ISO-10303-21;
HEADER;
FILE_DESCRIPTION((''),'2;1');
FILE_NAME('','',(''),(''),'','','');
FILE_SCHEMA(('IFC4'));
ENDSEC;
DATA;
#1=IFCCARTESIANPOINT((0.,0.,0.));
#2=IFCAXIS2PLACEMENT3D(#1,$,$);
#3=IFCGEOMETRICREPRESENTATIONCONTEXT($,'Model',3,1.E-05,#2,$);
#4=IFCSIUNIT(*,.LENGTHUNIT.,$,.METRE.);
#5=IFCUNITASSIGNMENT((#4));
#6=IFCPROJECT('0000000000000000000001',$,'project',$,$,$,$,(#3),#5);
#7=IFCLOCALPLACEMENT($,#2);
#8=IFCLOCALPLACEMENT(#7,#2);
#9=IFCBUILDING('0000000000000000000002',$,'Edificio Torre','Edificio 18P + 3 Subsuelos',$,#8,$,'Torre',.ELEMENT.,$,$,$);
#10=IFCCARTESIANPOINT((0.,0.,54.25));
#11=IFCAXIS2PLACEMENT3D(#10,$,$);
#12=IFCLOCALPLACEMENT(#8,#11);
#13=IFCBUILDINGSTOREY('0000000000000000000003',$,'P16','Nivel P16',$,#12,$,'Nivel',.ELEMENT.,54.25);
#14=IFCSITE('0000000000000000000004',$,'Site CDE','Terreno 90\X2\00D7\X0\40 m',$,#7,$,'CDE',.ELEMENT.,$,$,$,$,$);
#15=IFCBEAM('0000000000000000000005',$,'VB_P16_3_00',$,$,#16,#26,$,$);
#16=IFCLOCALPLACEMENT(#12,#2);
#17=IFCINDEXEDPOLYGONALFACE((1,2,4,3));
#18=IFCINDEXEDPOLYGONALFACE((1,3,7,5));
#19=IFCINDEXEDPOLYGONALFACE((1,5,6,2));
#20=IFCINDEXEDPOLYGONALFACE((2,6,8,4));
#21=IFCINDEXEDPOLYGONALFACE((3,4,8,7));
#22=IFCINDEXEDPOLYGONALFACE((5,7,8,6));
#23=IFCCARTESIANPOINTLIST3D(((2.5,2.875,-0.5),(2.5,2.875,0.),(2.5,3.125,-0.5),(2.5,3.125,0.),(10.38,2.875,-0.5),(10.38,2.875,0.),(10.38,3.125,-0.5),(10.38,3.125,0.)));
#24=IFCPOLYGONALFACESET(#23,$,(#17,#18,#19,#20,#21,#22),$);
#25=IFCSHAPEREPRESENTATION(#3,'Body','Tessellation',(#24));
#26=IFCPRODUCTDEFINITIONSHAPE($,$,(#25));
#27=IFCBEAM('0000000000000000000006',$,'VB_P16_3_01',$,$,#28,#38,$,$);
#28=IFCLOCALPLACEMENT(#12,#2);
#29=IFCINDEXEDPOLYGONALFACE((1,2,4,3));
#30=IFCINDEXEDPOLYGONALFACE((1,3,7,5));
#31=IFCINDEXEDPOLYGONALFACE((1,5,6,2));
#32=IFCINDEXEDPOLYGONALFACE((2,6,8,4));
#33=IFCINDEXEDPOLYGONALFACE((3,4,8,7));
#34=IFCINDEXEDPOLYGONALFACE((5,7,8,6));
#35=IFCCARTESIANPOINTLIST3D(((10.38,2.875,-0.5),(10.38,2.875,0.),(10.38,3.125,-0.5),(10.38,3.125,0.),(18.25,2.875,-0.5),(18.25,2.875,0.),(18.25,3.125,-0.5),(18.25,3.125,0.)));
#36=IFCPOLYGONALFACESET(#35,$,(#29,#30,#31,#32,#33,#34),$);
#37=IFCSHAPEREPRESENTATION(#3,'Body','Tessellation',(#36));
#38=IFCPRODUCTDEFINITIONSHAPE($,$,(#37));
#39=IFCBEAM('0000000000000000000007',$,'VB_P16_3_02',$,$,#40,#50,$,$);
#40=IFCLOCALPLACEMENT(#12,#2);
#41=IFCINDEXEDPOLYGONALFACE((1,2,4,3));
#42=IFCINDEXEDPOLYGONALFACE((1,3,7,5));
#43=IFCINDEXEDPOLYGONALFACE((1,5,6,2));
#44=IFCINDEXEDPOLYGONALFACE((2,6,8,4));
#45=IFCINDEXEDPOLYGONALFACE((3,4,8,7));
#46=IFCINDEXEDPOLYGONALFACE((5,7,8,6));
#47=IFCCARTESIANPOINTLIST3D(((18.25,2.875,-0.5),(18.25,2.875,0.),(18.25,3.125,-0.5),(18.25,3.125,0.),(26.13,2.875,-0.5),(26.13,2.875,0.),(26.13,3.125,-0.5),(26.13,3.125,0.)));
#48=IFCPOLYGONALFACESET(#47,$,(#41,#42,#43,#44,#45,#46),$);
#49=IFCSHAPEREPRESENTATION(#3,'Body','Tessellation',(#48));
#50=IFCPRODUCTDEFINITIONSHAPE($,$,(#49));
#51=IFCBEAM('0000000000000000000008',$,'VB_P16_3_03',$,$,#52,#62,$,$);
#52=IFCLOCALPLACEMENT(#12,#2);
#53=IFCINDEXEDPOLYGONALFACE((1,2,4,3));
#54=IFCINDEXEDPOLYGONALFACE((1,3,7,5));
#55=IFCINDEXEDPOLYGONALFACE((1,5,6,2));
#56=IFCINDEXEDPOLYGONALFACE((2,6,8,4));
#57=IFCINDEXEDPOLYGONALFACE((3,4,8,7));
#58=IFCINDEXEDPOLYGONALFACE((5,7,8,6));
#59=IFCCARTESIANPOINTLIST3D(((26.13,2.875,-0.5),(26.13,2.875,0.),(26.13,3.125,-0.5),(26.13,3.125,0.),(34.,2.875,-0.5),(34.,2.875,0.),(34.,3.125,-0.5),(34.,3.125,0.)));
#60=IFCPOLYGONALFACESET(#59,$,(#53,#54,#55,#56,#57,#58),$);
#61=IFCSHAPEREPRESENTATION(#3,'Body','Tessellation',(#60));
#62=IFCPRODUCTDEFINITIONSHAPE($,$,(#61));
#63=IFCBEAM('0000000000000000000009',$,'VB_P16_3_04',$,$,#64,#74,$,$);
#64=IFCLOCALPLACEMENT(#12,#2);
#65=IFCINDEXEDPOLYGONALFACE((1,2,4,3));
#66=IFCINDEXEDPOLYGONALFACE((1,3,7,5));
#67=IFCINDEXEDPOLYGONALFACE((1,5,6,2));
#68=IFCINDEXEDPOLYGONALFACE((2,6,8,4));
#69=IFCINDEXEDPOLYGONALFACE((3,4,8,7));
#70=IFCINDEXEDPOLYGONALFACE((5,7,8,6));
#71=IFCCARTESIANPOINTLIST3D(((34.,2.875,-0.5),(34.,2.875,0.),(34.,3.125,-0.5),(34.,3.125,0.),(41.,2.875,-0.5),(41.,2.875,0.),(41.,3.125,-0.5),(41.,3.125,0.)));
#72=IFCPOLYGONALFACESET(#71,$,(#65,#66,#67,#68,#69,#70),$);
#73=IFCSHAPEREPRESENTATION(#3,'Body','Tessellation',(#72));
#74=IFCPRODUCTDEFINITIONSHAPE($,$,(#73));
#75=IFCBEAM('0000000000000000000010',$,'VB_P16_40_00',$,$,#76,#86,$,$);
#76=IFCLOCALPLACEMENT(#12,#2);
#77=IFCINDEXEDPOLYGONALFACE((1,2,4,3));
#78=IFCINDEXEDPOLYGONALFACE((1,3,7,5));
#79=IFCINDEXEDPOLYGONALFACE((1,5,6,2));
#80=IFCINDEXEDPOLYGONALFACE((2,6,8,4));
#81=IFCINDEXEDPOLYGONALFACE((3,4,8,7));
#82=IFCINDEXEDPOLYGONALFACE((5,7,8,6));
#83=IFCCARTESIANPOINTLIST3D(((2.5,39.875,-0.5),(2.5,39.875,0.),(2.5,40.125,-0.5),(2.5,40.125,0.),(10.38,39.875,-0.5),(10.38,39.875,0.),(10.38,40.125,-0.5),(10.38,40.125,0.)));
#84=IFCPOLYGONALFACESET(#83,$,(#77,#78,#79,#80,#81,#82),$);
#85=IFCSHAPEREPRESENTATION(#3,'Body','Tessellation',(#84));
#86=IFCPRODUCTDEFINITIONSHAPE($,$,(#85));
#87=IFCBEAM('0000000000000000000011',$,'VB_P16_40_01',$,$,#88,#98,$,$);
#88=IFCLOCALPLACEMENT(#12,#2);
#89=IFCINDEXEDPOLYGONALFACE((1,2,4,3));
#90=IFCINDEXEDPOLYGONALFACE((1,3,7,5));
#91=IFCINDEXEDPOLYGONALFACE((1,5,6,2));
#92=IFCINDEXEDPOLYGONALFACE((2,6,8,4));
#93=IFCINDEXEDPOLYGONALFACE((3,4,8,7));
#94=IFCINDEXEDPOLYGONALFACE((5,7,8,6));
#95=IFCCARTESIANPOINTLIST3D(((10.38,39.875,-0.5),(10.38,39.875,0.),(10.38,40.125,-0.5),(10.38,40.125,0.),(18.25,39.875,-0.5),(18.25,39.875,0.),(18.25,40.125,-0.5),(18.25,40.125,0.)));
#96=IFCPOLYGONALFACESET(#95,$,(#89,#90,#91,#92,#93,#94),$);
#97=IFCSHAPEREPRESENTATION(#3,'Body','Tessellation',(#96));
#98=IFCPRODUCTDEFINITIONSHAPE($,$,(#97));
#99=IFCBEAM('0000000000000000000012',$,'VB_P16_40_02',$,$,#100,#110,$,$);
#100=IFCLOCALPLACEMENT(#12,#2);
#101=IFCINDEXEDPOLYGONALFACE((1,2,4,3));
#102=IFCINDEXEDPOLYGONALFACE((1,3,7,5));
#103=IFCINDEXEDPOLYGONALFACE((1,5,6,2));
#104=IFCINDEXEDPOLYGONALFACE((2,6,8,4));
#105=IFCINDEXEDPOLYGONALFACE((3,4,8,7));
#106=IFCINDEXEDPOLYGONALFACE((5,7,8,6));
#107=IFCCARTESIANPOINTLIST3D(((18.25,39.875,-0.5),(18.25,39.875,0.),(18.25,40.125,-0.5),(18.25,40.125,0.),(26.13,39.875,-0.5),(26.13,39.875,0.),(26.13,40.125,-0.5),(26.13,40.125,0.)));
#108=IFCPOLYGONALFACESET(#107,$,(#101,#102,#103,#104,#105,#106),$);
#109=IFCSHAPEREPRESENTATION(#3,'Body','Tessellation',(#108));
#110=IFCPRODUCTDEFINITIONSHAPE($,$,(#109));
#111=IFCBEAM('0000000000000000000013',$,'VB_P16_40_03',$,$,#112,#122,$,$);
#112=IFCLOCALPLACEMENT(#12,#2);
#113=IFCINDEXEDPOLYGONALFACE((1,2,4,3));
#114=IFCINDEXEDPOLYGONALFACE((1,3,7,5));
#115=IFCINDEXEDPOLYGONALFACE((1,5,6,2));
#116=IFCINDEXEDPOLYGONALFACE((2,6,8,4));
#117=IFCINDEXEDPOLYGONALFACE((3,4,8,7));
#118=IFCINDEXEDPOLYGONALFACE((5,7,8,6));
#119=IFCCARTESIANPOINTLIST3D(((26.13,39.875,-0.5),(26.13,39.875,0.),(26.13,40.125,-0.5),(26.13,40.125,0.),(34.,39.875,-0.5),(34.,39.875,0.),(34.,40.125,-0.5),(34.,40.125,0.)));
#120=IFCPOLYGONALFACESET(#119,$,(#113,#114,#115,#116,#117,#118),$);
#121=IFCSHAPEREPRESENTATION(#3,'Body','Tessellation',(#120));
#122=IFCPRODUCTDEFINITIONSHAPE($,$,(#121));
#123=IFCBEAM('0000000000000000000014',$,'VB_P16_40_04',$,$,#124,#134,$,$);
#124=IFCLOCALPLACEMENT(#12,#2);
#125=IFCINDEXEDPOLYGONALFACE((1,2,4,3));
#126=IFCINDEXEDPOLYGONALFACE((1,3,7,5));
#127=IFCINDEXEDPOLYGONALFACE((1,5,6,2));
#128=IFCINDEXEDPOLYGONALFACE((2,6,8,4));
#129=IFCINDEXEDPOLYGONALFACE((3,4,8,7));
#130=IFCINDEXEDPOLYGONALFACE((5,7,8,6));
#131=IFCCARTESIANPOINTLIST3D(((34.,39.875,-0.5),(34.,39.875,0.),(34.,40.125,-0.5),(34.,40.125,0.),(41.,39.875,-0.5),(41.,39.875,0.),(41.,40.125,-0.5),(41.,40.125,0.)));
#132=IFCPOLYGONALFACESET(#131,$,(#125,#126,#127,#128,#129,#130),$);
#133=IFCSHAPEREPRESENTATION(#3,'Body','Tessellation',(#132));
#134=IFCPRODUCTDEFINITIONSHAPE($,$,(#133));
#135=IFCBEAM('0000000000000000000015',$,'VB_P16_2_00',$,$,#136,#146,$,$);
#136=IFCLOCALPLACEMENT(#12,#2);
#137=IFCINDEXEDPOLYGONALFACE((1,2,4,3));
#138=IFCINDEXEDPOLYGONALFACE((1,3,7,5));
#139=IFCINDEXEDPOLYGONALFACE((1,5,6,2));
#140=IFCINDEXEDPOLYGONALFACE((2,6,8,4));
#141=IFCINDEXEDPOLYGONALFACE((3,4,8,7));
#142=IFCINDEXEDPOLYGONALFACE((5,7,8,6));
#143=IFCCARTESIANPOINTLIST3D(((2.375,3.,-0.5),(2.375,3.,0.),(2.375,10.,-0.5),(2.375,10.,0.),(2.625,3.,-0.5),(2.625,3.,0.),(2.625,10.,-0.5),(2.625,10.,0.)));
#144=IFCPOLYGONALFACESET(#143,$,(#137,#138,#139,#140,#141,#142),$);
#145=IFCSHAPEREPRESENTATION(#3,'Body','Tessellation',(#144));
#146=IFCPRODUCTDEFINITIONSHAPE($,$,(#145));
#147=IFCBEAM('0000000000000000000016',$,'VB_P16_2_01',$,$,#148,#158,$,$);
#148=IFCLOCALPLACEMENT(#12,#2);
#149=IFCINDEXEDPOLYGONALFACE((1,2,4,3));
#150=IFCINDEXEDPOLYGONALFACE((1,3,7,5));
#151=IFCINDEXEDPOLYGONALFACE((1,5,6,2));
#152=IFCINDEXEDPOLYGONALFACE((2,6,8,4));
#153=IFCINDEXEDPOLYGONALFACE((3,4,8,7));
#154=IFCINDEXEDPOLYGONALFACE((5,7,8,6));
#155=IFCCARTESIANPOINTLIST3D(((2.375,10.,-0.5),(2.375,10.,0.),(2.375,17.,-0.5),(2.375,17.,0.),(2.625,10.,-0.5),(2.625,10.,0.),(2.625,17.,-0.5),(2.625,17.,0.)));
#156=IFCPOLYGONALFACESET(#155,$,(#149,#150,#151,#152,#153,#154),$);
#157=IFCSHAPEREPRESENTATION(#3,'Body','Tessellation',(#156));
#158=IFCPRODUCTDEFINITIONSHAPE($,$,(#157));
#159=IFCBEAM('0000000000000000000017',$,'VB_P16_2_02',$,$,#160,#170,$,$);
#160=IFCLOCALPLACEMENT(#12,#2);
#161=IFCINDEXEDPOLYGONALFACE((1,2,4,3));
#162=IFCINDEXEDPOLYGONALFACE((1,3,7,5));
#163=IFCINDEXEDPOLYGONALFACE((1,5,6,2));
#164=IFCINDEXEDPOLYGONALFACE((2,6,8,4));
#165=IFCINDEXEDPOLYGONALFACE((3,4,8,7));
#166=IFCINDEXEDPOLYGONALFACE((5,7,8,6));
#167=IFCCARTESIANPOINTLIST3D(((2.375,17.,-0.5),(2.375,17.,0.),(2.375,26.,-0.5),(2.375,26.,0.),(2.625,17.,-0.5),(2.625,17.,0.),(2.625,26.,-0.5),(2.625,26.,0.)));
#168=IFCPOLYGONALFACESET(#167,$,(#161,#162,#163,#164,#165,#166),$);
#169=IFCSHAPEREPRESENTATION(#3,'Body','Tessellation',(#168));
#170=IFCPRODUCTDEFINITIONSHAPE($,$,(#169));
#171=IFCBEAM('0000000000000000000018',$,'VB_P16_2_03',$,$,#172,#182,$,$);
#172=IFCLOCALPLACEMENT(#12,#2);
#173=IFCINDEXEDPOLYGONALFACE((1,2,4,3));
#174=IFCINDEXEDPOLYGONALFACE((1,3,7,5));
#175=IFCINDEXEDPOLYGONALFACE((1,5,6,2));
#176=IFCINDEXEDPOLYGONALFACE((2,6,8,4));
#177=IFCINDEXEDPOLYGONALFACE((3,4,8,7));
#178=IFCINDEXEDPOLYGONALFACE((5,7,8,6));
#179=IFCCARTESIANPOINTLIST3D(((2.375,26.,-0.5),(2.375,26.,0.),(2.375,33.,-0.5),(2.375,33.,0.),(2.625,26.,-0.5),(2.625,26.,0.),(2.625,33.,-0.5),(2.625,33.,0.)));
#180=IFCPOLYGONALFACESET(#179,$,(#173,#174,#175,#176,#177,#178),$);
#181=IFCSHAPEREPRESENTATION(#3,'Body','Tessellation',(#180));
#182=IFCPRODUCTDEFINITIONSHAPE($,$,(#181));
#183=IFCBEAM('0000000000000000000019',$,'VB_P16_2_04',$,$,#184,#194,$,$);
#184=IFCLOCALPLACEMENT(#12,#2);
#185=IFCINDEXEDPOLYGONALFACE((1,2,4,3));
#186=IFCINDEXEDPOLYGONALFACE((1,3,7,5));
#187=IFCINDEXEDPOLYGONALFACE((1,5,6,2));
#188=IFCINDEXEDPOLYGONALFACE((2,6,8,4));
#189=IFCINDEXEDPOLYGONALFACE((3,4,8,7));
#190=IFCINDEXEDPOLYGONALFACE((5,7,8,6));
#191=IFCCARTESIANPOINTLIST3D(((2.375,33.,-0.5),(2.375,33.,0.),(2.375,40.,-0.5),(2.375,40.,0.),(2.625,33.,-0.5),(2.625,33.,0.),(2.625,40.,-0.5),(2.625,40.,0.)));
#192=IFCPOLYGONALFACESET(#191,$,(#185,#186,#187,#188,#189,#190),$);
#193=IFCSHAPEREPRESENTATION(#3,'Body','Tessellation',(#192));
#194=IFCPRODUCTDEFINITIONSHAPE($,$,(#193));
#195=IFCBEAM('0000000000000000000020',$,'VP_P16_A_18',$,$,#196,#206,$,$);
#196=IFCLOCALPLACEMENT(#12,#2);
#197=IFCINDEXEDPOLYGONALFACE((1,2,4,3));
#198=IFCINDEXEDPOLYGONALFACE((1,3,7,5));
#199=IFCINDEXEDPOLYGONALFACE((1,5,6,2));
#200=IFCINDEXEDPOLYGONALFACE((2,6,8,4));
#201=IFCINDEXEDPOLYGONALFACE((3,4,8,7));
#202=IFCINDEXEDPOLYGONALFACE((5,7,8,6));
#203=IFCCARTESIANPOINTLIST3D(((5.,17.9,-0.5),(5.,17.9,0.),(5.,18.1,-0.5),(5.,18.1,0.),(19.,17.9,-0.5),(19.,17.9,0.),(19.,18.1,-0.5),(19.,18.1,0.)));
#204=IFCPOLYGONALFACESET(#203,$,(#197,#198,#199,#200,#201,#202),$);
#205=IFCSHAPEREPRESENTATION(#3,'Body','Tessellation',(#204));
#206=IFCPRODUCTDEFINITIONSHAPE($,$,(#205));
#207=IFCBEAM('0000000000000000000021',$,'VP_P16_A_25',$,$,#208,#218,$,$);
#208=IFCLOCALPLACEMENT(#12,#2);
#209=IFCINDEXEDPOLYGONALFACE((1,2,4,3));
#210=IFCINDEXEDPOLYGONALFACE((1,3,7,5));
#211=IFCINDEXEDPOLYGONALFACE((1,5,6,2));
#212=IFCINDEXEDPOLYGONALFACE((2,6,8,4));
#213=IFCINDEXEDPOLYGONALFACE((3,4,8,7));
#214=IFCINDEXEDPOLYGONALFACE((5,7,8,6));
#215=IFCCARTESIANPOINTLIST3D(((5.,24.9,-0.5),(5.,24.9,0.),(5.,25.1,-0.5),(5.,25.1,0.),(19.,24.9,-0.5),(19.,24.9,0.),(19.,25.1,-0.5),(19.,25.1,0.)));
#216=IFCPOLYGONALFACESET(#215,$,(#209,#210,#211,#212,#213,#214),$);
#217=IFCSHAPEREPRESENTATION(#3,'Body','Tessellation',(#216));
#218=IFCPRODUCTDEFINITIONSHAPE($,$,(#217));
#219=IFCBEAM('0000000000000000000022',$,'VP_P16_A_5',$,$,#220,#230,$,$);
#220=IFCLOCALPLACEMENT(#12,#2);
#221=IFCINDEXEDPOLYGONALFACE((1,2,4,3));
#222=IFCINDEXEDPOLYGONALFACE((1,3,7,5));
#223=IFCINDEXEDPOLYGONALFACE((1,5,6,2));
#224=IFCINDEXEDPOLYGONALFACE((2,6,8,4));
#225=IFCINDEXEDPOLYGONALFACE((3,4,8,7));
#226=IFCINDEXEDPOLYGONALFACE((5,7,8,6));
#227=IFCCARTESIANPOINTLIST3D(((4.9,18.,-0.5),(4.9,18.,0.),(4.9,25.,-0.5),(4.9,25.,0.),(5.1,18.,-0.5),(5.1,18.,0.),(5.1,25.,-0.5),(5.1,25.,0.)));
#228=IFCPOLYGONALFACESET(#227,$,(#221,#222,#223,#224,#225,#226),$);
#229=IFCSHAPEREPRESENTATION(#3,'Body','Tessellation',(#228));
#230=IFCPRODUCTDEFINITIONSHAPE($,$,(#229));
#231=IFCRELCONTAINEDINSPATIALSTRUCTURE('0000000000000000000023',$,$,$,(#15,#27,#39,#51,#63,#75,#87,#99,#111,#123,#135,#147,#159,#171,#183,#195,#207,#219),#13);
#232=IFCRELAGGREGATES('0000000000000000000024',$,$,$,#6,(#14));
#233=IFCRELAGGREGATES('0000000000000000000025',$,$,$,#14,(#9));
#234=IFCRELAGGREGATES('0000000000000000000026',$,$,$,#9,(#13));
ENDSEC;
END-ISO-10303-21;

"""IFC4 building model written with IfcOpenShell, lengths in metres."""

from ifc_helpers import new_model, si_unit, frame, origin, origin_2d, place, context, project, spatial, rectangle, extrude, element, save


model = new_model("IFC4")

# Units and contexts
model_context = context("Model", 3, precision=1e-05, world=origin())
ifc_project = project(units=[si_unit("LENGTHUNIT", "METRE")], contexts=[model_context])

# Site, building, storey
site_placement = place(None, origin())
site = spatial("IfcSite", under=ifc_project, at=site_placement, Name="Site CDE", Description="Terreno 90×40 m", LongName="CDE", CompositionType="ELEMENT")
building_placement = place(site_placement, origin())
building = spatial("IfcBuilding", under=site, at=building_placement, Name="Edificio Torre", Description="Edificio 18P + 3 Subsuelos", LongName="Torre", CompositionType="ELEMENT")
storey_placement = place(building_placement, frame((0.0, 0.0, 54.25)))
storey = spatial("IfcBuildingStorey", under=building, at=storey_placement, Name="P16", Description="Nivel P16", LongName="Nivel", CompositionType="ELEMENT", Elevation=54.25)

# Beams
beam_1_placement = place(storey_placement, frame((6.44, 3.0, -0.5)))
element("IfcBeam", 1, at=beam_1_placement, inside=storey, Name="VB_P16_3_00", context=model_context, shape_type="SweptSolid", body=[
    extrude(rectangle(XDim=7.88, YDim=0.25, at=origin_2d()), origin(), (0.0, 0.0, 1.0), 0.5),
])
beam_2_placement = place(storey_placement, frame((14.315, 3.0, -0.5)))
element("IfcBeam", 2, at=beam_2_placement, inside=storey, Name="VB_P16_3_01", context=model_context, shape_type="SweptSolid", body=[
    extrude(rectangle(XDim=7.87, YDim=0.25, at=origin_2d()), origin(), (0.0, 0.0, 1.0), 0.5),
])
beam_3_placement = place(storey_placement, frame((22.19, 3.0, -0.5)))
element("IfcBeam", 3, at=beam_3_placement, inside=storey, Name="VB_P16_3_02", context=model_context, shape_type="SweptSolid", body=[
    extrude(rectangle(XDim=7.88, YDim=0.25, at=origin_2d()), origin(), (0.0, 0.0, 1.0), 0.5),
])
beam_4_placement = place(storey_placement, frame((30.065, 3.0, -0.5)))
element("IfcBeam", 4, at=beam_4_placement, inside=storey, Name="VB_P16_3_03", context=model_context, shape_type="SweptSolid", body=[
    extrude(rectangle(XDim=7.87, YDim=0.25, at=origin_2d()), origin(), (0.0, 0.0, 1.0), 0.5),
])
beam_5_placement = place(storey_placement, frame((37.5, 3.0, -0.5)))
element("IfcBeam", 5, at=beam_5_placement, inside=storey, Name="VB_P16_3_04", context=model_context, shape_type="SweptSolid", body=[
    extrude(rectangle(XDim=7.0, YDim=0.25, at=origin_2d()), origin(), (0.0, 0.0, 1.0), 0.5),
])
beam_6_placement = place(storey_placement, frame((6.44, 40.0, -0.5)))
element("IfcBeam", 6, at=beam_6_placement, inside=storey, Name="VB_P16_40_00", context=model_context, shape_type="SweptSolid", body=[
    extrude(rectangle(XDim=7.88, YDim=0.25, at=origin_2d()), origin(), (0.0, 0.0, 1.0), 0.5),
])
beam_7_placement = place(storey_placement, frame((14.315, 40.0, -0.5)))
element("IfcBeam", 7, at=beam_7_placement, inside=storey, Name="VB_P16_40_01", context=model_context, shape_type="SweptSolid", body=[
    extrude(rectangle(XDim=7.87, YDim=0.25, at=origin_2d()), origin(), (0.0, 0.0, 1.0), 0.5),
])
beam_8_placement = place(storey_placement, frame((22.19, 40.0, -0.5)))
element("IfcBeam", 8, at=beam_8_placement, inside=storey, Name="VB_P16_40_02", context=model_context, shape_type="SweptSolid", body=[
    extrude(rectangle(XDim=7.88, YDim=0.25, at=origin_2d()), origin(), (0.0, 0.0, 1.0), 0.5),
])
beam_9_placement = place(storey_placement, frame((30.065, 40.0, -0.5)))
element("IfcBeam", 9, at=beam_9_placement, inside=storey, Name="VB_P16_40_03", context=model_context, shape_type="SweptSolid", body=[
    extrude(rectangle(XDim=7.87, YDim=0.25, at=origin_2d()), origin(), (0.0, 0.0, 1.0), 0.5),
])
beam_10_placement = place(storey_placement, frame((37.5, 40.0, -0.5)))
element("IfcBeam", 10, at=beam_10_placement, inside=storey, Name="VB_P16_40_04", context=model_context, shape_type="SweptSolid", body=[
    extrude(rectangle(XDim=7.0, YDim=0.25, at=origin_2d()), origin(), (0.0, 0.0, 1.0), 0.5),
])
for number, where, name in (
    (11, (2.5, 6.5, -0.5), "VB_P16_2_00"),
    (12, (2.5, 13.5, -0.5), "VB_P16_2_01"),
):
    element("IfcBeam", number, at=place(storey_placement, frame(where)), inside=storey, Name=name, context=model_context, shape_type="SweptSolid", body=[
        extrude(rectangle(XDim=0.25, YDim=7.0, at=origin_2d()), origin(), (0.0, 0.0, 1.0), 0.5),
    ])
beam_11_placement = place(storey_placement, frame((2.5, 21.5, -0.5)))
element("IfcBeam", 13, at=beam_11_placement, inside=storey, Name="VB_P16_2_02", context=model_context, shape_type="SweptSolid", body=[
    extrude(rectangle(XDim=0.25, YDim=9.0, at=origin_2d()), origin(), (0.0, 0.0, 1.0), 0.5),
])
for number, where, name in (
    (14, (2.5, 29.5, -0.5), "VB_P16_2_03"),
    (15, (2.5, 36.5, -0.5), "VB_P16_2_04"),
):
    element("IfcBeam", number, at=place(storey_placement, frame(where)), inside=storey, Name=name, context=model_context, shape_type="SweptSolid", body=[
        extrude(rectangle(XDim=0.25, YDim=7.0, at=origin_2d()), origin(), (0.0, 0.0, 1.0), 0.5),
    ])
for number, where, name in (
    (16, (12.0, 18.0, -0.5), "VP_P16_A_18"),
    (17, (12.0, 25.0, -0.5), "VP_P16_A_25"),
):
    element("IfcBeam", number, at=place(storey_placement, frame(where)), inside=storey, Name=name, context=model_context, shape_type="SweptSolid", body=[
        extrude(rectangle(XDim=14.0, YDim=0.2, at=origin_2d()), origin(), (0.0, 0.0, 1.0), 0.5),
    ])
beam_12_placement = place(storey_placement, frame((5.0, 21.5, -0.5)))
element("IfcBeam", 18, at=beam_12_placement, inside=storey, Name="VP_P16_A_5", context=model_context, shape_type="SweptSolid", body=[
    extrude(rectangle(XDim=0.2, YDim=7.0, at=origin_2d()), origin(), (0.0, 0.0, 1.0), 0.5),
])

save(model, "model.ifc")
